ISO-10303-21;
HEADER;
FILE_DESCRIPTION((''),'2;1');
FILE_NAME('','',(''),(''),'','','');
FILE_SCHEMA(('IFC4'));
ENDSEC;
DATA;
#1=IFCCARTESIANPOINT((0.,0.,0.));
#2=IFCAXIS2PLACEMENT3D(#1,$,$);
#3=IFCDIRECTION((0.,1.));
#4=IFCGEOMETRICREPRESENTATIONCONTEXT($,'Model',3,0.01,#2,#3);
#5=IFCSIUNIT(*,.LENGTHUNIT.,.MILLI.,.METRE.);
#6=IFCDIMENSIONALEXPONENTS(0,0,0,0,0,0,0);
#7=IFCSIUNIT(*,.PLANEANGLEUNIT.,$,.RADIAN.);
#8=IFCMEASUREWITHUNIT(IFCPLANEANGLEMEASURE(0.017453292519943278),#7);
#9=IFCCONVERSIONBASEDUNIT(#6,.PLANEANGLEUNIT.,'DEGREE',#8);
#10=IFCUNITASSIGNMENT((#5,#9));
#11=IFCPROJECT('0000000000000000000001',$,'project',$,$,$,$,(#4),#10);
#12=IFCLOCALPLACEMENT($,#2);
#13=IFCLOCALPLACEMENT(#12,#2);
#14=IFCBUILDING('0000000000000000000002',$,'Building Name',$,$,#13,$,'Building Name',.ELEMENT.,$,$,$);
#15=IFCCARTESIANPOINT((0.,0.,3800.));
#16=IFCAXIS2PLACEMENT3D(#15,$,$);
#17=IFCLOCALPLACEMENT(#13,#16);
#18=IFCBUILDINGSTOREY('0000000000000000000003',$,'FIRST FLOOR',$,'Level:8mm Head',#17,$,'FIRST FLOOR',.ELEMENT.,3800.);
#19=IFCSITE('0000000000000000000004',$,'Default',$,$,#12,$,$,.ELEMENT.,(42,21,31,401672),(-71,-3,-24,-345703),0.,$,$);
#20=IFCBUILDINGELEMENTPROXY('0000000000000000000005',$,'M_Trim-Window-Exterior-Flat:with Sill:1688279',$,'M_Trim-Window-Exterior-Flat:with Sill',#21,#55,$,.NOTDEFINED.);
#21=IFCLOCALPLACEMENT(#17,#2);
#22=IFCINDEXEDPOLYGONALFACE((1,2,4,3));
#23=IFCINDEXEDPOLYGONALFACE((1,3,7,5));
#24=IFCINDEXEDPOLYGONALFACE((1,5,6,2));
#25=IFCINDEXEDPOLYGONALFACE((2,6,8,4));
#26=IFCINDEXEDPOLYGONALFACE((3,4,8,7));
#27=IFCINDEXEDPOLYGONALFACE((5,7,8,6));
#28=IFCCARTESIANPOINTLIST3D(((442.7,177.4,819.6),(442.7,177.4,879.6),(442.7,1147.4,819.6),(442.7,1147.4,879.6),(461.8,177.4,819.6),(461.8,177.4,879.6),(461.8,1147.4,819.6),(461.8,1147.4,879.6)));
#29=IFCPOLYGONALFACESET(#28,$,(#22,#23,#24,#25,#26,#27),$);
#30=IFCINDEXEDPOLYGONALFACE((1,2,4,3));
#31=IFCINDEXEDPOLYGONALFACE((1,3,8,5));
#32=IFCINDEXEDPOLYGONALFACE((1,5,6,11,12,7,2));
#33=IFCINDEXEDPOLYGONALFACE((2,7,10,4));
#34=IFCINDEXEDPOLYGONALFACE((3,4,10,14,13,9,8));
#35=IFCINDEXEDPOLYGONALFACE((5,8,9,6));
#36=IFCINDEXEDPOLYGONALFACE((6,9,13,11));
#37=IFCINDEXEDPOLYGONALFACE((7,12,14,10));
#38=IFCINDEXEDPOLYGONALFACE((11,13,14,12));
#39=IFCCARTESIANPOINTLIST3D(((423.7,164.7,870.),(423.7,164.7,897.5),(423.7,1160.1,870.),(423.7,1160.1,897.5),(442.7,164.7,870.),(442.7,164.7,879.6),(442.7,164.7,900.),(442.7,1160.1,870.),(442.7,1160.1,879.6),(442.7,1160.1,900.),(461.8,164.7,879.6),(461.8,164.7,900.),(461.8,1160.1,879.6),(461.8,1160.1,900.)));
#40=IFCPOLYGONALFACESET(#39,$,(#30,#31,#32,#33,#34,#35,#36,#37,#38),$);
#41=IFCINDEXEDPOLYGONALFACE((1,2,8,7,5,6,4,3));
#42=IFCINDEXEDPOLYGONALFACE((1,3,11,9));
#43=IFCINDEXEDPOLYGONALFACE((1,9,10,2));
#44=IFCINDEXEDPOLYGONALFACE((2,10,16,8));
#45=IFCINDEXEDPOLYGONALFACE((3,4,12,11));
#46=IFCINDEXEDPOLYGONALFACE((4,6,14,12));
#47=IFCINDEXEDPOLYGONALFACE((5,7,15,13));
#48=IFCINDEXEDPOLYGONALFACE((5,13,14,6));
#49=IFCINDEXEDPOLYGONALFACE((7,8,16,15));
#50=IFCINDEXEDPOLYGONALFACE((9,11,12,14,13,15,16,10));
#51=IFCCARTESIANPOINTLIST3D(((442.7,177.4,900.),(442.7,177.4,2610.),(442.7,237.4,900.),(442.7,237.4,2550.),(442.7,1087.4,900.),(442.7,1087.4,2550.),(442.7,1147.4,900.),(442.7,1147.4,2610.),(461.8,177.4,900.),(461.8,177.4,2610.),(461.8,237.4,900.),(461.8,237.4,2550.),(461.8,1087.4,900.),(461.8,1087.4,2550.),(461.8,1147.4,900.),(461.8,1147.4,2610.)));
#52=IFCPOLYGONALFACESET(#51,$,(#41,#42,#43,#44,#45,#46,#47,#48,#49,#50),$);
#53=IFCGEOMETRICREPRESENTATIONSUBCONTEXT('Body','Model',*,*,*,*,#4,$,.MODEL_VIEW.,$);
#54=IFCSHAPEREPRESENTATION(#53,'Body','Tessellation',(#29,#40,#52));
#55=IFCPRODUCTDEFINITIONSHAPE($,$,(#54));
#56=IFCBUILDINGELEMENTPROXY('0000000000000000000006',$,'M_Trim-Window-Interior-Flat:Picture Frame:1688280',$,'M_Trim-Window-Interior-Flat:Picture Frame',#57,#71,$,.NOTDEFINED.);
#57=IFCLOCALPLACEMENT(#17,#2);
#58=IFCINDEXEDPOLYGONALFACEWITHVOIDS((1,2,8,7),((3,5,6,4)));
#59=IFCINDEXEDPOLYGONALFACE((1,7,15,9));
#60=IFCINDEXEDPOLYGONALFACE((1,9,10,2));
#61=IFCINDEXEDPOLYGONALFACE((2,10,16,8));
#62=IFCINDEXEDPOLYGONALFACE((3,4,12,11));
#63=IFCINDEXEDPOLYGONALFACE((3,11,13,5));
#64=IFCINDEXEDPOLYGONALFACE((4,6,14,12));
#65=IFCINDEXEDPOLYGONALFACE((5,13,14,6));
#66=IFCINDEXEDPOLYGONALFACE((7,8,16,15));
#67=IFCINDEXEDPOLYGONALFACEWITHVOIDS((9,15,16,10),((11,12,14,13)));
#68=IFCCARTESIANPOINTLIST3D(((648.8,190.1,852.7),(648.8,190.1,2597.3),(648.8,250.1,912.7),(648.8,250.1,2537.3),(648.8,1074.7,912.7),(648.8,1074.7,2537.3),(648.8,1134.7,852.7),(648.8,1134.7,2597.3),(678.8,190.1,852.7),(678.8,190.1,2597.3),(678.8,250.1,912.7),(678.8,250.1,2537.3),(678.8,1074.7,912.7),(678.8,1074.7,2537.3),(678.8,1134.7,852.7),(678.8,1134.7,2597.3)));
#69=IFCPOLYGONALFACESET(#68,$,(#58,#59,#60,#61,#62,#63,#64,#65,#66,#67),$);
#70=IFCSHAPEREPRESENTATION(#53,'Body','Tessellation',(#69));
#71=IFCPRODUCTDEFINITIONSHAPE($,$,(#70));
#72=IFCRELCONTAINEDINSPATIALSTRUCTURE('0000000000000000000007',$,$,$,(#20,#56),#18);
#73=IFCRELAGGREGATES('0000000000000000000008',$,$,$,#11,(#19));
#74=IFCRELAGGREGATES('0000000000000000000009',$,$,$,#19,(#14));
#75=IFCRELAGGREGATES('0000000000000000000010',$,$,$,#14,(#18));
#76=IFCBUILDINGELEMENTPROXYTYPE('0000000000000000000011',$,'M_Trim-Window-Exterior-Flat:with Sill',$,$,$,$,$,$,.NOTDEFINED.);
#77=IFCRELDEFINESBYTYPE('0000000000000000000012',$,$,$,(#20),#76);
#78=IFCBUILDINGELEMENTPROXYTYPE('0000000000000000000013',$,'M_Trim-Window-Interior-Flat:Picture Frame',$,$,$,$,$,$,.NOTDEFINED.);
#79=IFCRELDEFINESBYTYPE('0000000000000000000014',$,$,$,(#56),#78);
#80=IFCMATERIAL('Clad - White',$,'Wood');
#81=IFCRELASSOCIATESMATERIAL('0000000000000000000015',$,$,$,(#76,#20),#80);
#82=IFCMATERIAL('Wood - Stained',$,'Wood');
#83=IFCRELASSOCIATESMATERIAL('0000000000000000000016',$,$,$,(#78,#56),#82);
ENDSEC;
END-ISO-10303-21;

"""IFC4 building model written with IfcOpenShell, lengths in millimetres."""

from ifc_helpers import new_model, entity, si_unit, converted_unit, direction, frame, origin, place, context, subcontext, project, spatial, indexed_curve, outline, extrude, source, transform, mapped, material, type_object, type_shapes, element, save


model = new_model("IFC4")

# Units and contexts
model_context = context("Model", 3, precision=0.01, world=origin(), true_north=direction((0.0, 1.0)))
body_context = subcontext(model_context, "Body", "Model", "MODEL_VIEW")
ifc_project = project(units=[si_unit("LENGTHUNIT", "METRE", prefix="MILLI"), converted_unit("PLANEANGLEUNIT", "DEGREE", entity("IfcPlaneAngleMeasure", 0.017453292519943278), si_unit("PLANEANGLEUNIT", "RADIAN"), dimensions=[0, 0, 0, 0, 0, 0, 0])], contexts=[model_context])

# Site, building, storey
site_placement = place(None, origin())
site = spatial("IfcSite", under=ifc_project, at=site_placement, Name="Default", CompositionType="ELEMENT", RefLatitude=(42, 21, 31, 401672), RefLongitude=(-71, -3, -24, -345703), RefElevation=0.0)
building_placement = place(site_placement, origin())
building = spatial("IfcBuilding", under=site, at=building_placement, Name="Building Name", LongName="Building Name", CompositionType="ELEMENT")
storey_placement = place(building_placement, frame((0.0, 0.0, 3800.0)))
storey = spatial("IfcBuildingStorey", under=building, at=storey_placement, Name="FIRST FLOOR", ObjectType="Level:8mm Head", LongName="FIRST FLOOR", CompositionType="ELEMENT", Elevation=3800.0)

# Building element proxies
ifc_material_1 = material(Name="Clad - White", Category="Wood")
ifc_material_2 = material(Name="Wood - Stained", Category="Wood")
building_element_proxy_type_1 = type_object("IfcBuildingElementProxyType", Name="M_Trim-Window-Exterior-Flat:with Sill", PredefinedType="NOTDEFINED", material=ifc_material_1)
shared_shape_1 = source(origin(), body_context, "Body", "SweptSolid", [
    extrude(outline(indexed_curve([(-485.0, -30.0), (485.0, -30.0), (485.0, 30.0), (-485.0, 30.0), (-485.0, -30.0)], self_intersect=False)), frame((0.0, -1700.4, 0.0), z_axis=(0.0, 0.0, 1.0), x_axis=(-1.0, 0.0, 0.0)), (0.0, 0.0, 1.0), 19.0),
    extrude(outline(indexed_curve([(-19.0, -15.2), (0.0, -15.2), (0.0, -5.7), (19.0, -5.7), (19.0, 14.8), (0.0, 14.8), (-19.0, 12.3), (-19.0, -15.2)], self_intersect=False)), frame((-497.7, -1664.8, 19.0), z_axis=(1.0, 0.0, 0.0), x_axis=(0.0, 0.0, -1.0)), (0.0, 0.0, 1.0), 995.4),
    extrude(outline(indexed_curve([(-870.0, -485.0), (840.0, -485.0), (840.0, -425.0), (-810.0, -425.0), (-810.0, 425.0), (840.0, 425.0), (840.0, 485.0), (-870.0, 485.0), (-870.0, -485.0)], self_intersect=False)), frame((0.0, -810.0, 0.0), z_axis=(0.0, 0.0, 1.0), x_axis=(0.0, -1.0, 0.0)), (0.0, 0.0, 1.0), 19.0),
])
type_shapes(building_element_proxy_type_1, [shared_shape_1])
proxy_1_placement = place(storey_placement, frame((461.8, 662.4, 2550.0), z_axis=(-1.0, 0.0, 0.0), x_axis=(0.0, -1.0, 0.0)))
element("IfcBuildingElementProxy", 1, at=proxy_1_placement, inside=storey, type_object=building_element_proxy_type_1, material=ifc_material_1, Name="M_Trim-Window-Exterior-Flat:with Sill:1688279", ObjectType="M_Trim-Window-Exterior-Flat:with Sill", PredefinedType="NOTDEFINED", context=body_context, shape_type="MappedRepresentation", body=[
    mapped(shared_shape_1, transform((0.0, 0.0, 0.0), scale=1.0)),
])
building_element_proxy_type_2 = type_object("IfcBuildingElementProxyType", Name="M_Trim-Window-Interior-Flat:Picture Frame", PredefinedType="NOTDEFINED", material=ifc_material_2)
shared_shape_2 = source(origin(), body_context, "Body", "SweptSolid", [
    extrude(outline(indexed_curve([(-472.3, -872.3), (472.3, -872.3), (472.3, 872.3), (-472.3, 872.3), (-472.3, -872.3)], self_intersect=False), holes=[indexed_curve([(-412.3, -812.3), (-412.3, 812.3), (412.3, 812.3), (412.3, -812.3), (-412.3, -812.3)], self_intersect=False)]), frame((0.0, -825.0, 0.0), z_axis=(0.0, 0.0, 1.0), x_axis=(-1.0, 0.0, 0.0)), (0.0, 0.0, 1.0), 30.0),
])
type_shapes(building_element_proxy_type_2, [shared_shape_2])
proxy_2_placement = place(storey_placement, frame((648.8, 662.4, 2550.0), z_axis=(1.0, 0.0, 0.0), x_axis=(0.0, 1.0, 0.0)))
element("IfcBuildingElementProxy", 2, at=proxy_2_placement, inside=storey, type_object=building_element_proxy_type_2, material=ifc_material_2, Name="M_Trim-Window-Interior-Flat:Picture Frame:1688280", ObjectType="M_Trim-Window-Interior-Flat:Picture Frame", PredefinedType="NOTDEFINED", context=body_context, shape_type="MappedRepresentation", body=[
    mapped(shared_shape_2, transform((0.0, 0.0, 0.0), scale=1.0)),
])

save(model, "model.ifc")
